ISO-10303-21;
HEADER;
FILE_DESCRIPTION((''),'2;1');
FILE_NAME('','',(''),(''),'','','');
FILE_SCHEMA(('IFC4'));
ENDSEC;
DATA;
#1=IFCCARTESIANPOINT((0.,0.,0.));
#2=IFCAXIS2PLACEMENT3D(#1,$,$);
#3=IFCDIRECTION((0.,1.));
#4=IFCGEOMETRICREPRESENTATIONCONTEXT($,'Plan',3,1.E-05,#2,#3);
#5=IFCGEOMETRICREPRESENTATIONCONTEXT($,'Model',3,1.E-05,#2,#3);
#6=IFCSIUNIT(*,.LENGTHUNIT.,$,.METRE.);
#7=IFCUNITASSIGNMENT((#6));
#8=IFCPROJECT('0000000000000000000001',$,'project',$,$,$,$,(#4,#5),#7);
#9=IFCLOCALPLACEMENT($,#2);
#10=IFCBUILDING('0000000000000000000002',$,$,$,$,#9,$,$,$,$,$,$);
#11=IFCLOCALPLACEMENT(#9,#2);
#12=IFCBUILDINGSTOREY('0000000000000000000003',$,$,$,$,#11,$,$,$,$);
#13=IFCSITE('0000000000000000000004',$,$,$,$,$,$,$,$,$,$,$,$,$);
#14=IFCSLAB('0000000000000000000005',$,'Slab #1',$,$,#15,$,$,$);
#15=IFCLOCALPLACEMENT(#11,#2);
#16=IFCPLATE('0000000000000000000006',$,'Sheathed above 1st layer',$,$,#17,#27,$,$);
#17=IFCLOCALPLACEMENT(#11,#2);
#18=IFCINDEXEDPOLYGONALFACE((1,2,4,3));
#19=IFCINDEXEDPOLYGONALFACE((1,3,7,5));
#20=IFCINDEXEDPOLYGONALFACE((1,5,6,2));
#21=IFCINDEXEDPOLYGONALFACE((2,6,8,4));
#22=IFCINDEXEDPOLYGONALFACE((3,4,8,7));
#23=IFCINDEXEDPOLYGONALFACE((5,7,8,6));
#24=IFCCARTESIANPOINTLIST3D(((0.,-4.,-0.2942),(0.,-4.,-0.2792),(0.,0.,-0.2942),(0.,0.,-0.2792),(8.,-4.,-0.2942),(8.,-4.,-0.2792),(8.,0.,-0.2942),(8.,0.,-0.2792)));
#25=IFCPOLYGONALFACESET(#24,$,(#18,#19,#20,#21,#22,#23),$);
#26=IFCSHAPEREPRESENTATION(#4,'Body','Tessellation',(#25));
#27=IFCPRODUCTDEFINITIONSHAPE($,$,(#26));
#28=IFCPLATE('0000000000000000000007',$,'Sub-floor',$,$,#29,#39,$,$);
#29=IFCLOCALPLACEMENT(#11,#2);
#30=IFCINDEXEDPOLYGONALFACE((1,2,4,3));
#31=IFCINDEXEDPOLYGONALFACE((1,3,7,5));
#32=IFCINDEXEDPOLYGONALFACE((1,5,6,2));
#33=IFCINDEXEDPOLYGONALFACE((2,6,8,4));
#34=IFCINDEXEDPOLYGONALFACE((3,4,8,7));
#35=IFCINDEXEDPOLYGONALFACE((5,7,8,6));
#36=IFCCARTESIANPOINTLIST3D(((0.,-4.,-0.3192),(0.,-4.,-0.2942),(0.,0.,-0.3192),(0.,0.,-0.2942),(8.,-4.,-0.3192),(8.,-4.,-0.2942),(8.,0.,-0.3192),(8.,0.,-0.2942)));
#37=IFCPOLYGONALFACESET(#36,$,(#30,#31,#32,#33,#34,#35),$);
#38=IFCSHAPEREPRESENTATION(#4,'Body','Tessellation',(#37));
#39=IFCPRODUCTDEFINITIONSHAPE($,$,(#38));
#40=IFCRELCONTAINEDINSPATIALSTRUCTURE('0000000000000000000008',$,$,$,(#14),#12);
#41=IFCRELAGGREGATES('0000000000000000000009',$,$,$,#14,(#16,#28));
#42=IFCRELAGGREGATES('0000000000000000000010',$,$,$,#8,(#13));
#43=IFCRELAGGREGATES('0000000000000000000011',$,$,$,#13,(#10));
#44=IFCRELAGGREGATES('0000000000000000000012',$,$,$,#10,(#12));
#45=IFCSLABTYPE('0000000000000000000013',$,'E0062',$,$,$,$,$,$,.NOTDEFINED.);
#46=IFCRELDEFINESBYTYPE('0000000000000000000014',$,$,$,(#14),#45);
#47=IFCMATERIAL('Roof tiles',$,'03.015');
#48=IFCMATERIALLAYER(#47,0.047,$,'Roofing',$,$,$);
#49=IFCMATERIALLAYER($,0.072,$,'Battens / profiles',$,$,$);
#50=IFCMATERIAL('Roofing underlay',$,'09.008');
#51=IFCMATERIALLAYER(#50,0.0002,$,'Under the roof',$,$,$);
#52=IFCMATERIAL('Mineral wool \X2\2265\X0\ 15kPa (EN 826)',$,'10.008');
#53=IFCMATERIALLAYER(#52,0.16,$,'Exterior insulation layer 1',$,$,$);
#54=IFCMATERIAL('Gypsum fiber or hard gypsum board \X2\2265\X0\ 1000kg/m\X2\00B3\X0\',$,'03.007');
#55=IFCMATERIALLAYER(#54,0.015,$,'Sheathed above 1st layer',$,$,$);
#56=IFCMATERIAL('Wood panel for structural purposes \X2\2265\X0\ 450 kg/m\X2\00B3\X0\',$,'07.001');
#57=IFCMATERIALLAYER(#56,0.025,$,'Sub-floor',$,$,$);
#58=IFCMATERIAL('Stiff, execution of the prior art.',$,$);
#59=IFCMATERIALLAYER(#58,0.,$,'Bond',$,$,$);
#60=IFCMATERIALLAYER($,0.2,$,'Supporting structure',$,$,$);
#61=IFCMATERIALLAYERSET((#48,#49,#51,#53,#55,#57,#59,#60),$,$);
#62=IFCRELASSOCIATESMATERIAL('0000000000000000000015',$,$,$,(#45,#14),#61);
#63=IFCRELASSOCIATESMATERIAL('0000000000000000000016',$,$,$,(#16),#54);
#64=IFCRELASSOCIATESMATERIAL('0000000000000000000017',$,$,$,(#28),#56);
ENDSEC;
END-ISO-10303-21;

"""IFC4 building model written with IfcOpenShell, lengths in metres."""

from ifc_helpers import new_model, si_unit, direction, frame, frame_2d, origin, place, context, project, spatial, rectangle, extrude, material, layer, layer_set, type_object, element, aggregate, save


model = new_model("IFC4")

# Units and contexts
plan_context = context("Plan", 3, precision=1e-05, world=origin(), true_north=direction((0.0, 1.0)))
model_context = context("Model", 3, precision=1e-05, world=origin(), true_north=direction((0.0, 1.0)))
ifc_project = project(units=[si_unit("LENGTHUNIT", "METRE")], contexts=[plan_context, model_context])

# Site, building, storey
site = spatial("IfcSite", under=ifc_project)
building_placement = place(None, origin())
building = spatial("IfcBuilding", under=site, at=building_placement)
storey_placement = place(building_placement, origin())
storey = spatial("IfcBuildingStorey", under=building, at=storey_placement)

# Slab, plates
ifc_material_1 = material(Name="Roof tiles", Category="03.015")
ifc_layer_1 = layer(ifc_material_1, 0.047, Name="Roofing")
ifc_layer_2 = layer(None, 0.072, Name="Battens / profiles")
ifc_material_2 = material(Name="Roofing underlay", Category="09.008")
ifc_layer_3 = layer(ifc_material_2, 0.0002, Name="Under the roof")
ifc_material_3 = material(Name="Mineral wool ≥ 15kPa (EN 826)", Category="10.008")
ifc_layer_4 = layer(ifc_material_3, 0.16, Name="Exterior insulation layer 1")
ifc_material_4 = material(Name="Gypsum fiber or hard gypsum board ≥ 1000kg/m³", Category="03.007")
ifc_layer_5 = layer(ifc_material_4, 0.015, Name="Sheathed above 1st layer")
ifc_material_5 = material(Name="Wood panel for structural purposes ≥ 450 kg/m³", Category="07.001")
ifc_layer_6 = layer(ifc_material_5, 0.025, Name="Sub-floor")
ifc_material_6 = material(Name="Stiff, execution of the prior art.")
ifc_layer_7 = layer(ifc_material_6, 0.0, Name="Bond")
ifc_layer_8 = layer(None, 0.2, Name="Supporting structure")
ifc_layer_set = layer_set([ifc_layer_1, ifc_layer_2, ifc_layer_3, ifc_layer_4, ifc_layer_5, ifc_layer_6, ifc_layer_7, ifc_layer_8])
slab_type = type_object("IfcSlabType", Name="E0062", PredefinedType="NOTDEFINED", material=ifc_layer_set)
slab_placement = place(None, frame((0.0, 0.0, 0.0), z_axis=(0.0, 0.0, -1.0), x_axis=(1.0, 0.0, 0.0)))
slab = element("IfcSlab", 1, at=slab_placement, inside=storey, type_object=slab_type, material=ifc_layer_set, Name="Slab #1")
plate_1_placement = place(slab_placement, origin())
plate_1 = element("IfcPlate", 2, at=plate_1_placement, material=ifc_material_4, Name="Sheathed above 1st layer", context=plan_context, shape_type="SweptSolid", body=[
    extrude(rectangle(XDim=8.0, YDim=4.0, at=frame_2d((4.0, 2.0), x_axis=(1.0, 0.0))), frame((0.0, 0.0, 0.2792), z_axis=(0.0, 0.0, 1.0), x_axis=(1.0, 0.0, 0.0)), (0.0, 0.0, 1.0), 0.015),
])
plate_2_placement = place(slab_placement, origin())
plate_2 = element("IfcPlate", 3, at=plate_2_placement, material=ifc_material_5, Name="Sub-floor", context=plan_context, shape_type="SweptSolid", body=[
    extrude(rectangle(XDim=8.0, YDim=4.0, at=frame_2d((4.0, 2.0), x_axis=(1.0, 0.0))), frame((0.0, 0.0, 0.2942), z_axis=(0.0, 0.0, 1.0), x_axis=(1.0, 0.0, 0.0)), (0.0, 0.0, 1.0), 0.025),
])
aggregate(slab, [plate_1, plate_2])

save(model, "model.ifc")
